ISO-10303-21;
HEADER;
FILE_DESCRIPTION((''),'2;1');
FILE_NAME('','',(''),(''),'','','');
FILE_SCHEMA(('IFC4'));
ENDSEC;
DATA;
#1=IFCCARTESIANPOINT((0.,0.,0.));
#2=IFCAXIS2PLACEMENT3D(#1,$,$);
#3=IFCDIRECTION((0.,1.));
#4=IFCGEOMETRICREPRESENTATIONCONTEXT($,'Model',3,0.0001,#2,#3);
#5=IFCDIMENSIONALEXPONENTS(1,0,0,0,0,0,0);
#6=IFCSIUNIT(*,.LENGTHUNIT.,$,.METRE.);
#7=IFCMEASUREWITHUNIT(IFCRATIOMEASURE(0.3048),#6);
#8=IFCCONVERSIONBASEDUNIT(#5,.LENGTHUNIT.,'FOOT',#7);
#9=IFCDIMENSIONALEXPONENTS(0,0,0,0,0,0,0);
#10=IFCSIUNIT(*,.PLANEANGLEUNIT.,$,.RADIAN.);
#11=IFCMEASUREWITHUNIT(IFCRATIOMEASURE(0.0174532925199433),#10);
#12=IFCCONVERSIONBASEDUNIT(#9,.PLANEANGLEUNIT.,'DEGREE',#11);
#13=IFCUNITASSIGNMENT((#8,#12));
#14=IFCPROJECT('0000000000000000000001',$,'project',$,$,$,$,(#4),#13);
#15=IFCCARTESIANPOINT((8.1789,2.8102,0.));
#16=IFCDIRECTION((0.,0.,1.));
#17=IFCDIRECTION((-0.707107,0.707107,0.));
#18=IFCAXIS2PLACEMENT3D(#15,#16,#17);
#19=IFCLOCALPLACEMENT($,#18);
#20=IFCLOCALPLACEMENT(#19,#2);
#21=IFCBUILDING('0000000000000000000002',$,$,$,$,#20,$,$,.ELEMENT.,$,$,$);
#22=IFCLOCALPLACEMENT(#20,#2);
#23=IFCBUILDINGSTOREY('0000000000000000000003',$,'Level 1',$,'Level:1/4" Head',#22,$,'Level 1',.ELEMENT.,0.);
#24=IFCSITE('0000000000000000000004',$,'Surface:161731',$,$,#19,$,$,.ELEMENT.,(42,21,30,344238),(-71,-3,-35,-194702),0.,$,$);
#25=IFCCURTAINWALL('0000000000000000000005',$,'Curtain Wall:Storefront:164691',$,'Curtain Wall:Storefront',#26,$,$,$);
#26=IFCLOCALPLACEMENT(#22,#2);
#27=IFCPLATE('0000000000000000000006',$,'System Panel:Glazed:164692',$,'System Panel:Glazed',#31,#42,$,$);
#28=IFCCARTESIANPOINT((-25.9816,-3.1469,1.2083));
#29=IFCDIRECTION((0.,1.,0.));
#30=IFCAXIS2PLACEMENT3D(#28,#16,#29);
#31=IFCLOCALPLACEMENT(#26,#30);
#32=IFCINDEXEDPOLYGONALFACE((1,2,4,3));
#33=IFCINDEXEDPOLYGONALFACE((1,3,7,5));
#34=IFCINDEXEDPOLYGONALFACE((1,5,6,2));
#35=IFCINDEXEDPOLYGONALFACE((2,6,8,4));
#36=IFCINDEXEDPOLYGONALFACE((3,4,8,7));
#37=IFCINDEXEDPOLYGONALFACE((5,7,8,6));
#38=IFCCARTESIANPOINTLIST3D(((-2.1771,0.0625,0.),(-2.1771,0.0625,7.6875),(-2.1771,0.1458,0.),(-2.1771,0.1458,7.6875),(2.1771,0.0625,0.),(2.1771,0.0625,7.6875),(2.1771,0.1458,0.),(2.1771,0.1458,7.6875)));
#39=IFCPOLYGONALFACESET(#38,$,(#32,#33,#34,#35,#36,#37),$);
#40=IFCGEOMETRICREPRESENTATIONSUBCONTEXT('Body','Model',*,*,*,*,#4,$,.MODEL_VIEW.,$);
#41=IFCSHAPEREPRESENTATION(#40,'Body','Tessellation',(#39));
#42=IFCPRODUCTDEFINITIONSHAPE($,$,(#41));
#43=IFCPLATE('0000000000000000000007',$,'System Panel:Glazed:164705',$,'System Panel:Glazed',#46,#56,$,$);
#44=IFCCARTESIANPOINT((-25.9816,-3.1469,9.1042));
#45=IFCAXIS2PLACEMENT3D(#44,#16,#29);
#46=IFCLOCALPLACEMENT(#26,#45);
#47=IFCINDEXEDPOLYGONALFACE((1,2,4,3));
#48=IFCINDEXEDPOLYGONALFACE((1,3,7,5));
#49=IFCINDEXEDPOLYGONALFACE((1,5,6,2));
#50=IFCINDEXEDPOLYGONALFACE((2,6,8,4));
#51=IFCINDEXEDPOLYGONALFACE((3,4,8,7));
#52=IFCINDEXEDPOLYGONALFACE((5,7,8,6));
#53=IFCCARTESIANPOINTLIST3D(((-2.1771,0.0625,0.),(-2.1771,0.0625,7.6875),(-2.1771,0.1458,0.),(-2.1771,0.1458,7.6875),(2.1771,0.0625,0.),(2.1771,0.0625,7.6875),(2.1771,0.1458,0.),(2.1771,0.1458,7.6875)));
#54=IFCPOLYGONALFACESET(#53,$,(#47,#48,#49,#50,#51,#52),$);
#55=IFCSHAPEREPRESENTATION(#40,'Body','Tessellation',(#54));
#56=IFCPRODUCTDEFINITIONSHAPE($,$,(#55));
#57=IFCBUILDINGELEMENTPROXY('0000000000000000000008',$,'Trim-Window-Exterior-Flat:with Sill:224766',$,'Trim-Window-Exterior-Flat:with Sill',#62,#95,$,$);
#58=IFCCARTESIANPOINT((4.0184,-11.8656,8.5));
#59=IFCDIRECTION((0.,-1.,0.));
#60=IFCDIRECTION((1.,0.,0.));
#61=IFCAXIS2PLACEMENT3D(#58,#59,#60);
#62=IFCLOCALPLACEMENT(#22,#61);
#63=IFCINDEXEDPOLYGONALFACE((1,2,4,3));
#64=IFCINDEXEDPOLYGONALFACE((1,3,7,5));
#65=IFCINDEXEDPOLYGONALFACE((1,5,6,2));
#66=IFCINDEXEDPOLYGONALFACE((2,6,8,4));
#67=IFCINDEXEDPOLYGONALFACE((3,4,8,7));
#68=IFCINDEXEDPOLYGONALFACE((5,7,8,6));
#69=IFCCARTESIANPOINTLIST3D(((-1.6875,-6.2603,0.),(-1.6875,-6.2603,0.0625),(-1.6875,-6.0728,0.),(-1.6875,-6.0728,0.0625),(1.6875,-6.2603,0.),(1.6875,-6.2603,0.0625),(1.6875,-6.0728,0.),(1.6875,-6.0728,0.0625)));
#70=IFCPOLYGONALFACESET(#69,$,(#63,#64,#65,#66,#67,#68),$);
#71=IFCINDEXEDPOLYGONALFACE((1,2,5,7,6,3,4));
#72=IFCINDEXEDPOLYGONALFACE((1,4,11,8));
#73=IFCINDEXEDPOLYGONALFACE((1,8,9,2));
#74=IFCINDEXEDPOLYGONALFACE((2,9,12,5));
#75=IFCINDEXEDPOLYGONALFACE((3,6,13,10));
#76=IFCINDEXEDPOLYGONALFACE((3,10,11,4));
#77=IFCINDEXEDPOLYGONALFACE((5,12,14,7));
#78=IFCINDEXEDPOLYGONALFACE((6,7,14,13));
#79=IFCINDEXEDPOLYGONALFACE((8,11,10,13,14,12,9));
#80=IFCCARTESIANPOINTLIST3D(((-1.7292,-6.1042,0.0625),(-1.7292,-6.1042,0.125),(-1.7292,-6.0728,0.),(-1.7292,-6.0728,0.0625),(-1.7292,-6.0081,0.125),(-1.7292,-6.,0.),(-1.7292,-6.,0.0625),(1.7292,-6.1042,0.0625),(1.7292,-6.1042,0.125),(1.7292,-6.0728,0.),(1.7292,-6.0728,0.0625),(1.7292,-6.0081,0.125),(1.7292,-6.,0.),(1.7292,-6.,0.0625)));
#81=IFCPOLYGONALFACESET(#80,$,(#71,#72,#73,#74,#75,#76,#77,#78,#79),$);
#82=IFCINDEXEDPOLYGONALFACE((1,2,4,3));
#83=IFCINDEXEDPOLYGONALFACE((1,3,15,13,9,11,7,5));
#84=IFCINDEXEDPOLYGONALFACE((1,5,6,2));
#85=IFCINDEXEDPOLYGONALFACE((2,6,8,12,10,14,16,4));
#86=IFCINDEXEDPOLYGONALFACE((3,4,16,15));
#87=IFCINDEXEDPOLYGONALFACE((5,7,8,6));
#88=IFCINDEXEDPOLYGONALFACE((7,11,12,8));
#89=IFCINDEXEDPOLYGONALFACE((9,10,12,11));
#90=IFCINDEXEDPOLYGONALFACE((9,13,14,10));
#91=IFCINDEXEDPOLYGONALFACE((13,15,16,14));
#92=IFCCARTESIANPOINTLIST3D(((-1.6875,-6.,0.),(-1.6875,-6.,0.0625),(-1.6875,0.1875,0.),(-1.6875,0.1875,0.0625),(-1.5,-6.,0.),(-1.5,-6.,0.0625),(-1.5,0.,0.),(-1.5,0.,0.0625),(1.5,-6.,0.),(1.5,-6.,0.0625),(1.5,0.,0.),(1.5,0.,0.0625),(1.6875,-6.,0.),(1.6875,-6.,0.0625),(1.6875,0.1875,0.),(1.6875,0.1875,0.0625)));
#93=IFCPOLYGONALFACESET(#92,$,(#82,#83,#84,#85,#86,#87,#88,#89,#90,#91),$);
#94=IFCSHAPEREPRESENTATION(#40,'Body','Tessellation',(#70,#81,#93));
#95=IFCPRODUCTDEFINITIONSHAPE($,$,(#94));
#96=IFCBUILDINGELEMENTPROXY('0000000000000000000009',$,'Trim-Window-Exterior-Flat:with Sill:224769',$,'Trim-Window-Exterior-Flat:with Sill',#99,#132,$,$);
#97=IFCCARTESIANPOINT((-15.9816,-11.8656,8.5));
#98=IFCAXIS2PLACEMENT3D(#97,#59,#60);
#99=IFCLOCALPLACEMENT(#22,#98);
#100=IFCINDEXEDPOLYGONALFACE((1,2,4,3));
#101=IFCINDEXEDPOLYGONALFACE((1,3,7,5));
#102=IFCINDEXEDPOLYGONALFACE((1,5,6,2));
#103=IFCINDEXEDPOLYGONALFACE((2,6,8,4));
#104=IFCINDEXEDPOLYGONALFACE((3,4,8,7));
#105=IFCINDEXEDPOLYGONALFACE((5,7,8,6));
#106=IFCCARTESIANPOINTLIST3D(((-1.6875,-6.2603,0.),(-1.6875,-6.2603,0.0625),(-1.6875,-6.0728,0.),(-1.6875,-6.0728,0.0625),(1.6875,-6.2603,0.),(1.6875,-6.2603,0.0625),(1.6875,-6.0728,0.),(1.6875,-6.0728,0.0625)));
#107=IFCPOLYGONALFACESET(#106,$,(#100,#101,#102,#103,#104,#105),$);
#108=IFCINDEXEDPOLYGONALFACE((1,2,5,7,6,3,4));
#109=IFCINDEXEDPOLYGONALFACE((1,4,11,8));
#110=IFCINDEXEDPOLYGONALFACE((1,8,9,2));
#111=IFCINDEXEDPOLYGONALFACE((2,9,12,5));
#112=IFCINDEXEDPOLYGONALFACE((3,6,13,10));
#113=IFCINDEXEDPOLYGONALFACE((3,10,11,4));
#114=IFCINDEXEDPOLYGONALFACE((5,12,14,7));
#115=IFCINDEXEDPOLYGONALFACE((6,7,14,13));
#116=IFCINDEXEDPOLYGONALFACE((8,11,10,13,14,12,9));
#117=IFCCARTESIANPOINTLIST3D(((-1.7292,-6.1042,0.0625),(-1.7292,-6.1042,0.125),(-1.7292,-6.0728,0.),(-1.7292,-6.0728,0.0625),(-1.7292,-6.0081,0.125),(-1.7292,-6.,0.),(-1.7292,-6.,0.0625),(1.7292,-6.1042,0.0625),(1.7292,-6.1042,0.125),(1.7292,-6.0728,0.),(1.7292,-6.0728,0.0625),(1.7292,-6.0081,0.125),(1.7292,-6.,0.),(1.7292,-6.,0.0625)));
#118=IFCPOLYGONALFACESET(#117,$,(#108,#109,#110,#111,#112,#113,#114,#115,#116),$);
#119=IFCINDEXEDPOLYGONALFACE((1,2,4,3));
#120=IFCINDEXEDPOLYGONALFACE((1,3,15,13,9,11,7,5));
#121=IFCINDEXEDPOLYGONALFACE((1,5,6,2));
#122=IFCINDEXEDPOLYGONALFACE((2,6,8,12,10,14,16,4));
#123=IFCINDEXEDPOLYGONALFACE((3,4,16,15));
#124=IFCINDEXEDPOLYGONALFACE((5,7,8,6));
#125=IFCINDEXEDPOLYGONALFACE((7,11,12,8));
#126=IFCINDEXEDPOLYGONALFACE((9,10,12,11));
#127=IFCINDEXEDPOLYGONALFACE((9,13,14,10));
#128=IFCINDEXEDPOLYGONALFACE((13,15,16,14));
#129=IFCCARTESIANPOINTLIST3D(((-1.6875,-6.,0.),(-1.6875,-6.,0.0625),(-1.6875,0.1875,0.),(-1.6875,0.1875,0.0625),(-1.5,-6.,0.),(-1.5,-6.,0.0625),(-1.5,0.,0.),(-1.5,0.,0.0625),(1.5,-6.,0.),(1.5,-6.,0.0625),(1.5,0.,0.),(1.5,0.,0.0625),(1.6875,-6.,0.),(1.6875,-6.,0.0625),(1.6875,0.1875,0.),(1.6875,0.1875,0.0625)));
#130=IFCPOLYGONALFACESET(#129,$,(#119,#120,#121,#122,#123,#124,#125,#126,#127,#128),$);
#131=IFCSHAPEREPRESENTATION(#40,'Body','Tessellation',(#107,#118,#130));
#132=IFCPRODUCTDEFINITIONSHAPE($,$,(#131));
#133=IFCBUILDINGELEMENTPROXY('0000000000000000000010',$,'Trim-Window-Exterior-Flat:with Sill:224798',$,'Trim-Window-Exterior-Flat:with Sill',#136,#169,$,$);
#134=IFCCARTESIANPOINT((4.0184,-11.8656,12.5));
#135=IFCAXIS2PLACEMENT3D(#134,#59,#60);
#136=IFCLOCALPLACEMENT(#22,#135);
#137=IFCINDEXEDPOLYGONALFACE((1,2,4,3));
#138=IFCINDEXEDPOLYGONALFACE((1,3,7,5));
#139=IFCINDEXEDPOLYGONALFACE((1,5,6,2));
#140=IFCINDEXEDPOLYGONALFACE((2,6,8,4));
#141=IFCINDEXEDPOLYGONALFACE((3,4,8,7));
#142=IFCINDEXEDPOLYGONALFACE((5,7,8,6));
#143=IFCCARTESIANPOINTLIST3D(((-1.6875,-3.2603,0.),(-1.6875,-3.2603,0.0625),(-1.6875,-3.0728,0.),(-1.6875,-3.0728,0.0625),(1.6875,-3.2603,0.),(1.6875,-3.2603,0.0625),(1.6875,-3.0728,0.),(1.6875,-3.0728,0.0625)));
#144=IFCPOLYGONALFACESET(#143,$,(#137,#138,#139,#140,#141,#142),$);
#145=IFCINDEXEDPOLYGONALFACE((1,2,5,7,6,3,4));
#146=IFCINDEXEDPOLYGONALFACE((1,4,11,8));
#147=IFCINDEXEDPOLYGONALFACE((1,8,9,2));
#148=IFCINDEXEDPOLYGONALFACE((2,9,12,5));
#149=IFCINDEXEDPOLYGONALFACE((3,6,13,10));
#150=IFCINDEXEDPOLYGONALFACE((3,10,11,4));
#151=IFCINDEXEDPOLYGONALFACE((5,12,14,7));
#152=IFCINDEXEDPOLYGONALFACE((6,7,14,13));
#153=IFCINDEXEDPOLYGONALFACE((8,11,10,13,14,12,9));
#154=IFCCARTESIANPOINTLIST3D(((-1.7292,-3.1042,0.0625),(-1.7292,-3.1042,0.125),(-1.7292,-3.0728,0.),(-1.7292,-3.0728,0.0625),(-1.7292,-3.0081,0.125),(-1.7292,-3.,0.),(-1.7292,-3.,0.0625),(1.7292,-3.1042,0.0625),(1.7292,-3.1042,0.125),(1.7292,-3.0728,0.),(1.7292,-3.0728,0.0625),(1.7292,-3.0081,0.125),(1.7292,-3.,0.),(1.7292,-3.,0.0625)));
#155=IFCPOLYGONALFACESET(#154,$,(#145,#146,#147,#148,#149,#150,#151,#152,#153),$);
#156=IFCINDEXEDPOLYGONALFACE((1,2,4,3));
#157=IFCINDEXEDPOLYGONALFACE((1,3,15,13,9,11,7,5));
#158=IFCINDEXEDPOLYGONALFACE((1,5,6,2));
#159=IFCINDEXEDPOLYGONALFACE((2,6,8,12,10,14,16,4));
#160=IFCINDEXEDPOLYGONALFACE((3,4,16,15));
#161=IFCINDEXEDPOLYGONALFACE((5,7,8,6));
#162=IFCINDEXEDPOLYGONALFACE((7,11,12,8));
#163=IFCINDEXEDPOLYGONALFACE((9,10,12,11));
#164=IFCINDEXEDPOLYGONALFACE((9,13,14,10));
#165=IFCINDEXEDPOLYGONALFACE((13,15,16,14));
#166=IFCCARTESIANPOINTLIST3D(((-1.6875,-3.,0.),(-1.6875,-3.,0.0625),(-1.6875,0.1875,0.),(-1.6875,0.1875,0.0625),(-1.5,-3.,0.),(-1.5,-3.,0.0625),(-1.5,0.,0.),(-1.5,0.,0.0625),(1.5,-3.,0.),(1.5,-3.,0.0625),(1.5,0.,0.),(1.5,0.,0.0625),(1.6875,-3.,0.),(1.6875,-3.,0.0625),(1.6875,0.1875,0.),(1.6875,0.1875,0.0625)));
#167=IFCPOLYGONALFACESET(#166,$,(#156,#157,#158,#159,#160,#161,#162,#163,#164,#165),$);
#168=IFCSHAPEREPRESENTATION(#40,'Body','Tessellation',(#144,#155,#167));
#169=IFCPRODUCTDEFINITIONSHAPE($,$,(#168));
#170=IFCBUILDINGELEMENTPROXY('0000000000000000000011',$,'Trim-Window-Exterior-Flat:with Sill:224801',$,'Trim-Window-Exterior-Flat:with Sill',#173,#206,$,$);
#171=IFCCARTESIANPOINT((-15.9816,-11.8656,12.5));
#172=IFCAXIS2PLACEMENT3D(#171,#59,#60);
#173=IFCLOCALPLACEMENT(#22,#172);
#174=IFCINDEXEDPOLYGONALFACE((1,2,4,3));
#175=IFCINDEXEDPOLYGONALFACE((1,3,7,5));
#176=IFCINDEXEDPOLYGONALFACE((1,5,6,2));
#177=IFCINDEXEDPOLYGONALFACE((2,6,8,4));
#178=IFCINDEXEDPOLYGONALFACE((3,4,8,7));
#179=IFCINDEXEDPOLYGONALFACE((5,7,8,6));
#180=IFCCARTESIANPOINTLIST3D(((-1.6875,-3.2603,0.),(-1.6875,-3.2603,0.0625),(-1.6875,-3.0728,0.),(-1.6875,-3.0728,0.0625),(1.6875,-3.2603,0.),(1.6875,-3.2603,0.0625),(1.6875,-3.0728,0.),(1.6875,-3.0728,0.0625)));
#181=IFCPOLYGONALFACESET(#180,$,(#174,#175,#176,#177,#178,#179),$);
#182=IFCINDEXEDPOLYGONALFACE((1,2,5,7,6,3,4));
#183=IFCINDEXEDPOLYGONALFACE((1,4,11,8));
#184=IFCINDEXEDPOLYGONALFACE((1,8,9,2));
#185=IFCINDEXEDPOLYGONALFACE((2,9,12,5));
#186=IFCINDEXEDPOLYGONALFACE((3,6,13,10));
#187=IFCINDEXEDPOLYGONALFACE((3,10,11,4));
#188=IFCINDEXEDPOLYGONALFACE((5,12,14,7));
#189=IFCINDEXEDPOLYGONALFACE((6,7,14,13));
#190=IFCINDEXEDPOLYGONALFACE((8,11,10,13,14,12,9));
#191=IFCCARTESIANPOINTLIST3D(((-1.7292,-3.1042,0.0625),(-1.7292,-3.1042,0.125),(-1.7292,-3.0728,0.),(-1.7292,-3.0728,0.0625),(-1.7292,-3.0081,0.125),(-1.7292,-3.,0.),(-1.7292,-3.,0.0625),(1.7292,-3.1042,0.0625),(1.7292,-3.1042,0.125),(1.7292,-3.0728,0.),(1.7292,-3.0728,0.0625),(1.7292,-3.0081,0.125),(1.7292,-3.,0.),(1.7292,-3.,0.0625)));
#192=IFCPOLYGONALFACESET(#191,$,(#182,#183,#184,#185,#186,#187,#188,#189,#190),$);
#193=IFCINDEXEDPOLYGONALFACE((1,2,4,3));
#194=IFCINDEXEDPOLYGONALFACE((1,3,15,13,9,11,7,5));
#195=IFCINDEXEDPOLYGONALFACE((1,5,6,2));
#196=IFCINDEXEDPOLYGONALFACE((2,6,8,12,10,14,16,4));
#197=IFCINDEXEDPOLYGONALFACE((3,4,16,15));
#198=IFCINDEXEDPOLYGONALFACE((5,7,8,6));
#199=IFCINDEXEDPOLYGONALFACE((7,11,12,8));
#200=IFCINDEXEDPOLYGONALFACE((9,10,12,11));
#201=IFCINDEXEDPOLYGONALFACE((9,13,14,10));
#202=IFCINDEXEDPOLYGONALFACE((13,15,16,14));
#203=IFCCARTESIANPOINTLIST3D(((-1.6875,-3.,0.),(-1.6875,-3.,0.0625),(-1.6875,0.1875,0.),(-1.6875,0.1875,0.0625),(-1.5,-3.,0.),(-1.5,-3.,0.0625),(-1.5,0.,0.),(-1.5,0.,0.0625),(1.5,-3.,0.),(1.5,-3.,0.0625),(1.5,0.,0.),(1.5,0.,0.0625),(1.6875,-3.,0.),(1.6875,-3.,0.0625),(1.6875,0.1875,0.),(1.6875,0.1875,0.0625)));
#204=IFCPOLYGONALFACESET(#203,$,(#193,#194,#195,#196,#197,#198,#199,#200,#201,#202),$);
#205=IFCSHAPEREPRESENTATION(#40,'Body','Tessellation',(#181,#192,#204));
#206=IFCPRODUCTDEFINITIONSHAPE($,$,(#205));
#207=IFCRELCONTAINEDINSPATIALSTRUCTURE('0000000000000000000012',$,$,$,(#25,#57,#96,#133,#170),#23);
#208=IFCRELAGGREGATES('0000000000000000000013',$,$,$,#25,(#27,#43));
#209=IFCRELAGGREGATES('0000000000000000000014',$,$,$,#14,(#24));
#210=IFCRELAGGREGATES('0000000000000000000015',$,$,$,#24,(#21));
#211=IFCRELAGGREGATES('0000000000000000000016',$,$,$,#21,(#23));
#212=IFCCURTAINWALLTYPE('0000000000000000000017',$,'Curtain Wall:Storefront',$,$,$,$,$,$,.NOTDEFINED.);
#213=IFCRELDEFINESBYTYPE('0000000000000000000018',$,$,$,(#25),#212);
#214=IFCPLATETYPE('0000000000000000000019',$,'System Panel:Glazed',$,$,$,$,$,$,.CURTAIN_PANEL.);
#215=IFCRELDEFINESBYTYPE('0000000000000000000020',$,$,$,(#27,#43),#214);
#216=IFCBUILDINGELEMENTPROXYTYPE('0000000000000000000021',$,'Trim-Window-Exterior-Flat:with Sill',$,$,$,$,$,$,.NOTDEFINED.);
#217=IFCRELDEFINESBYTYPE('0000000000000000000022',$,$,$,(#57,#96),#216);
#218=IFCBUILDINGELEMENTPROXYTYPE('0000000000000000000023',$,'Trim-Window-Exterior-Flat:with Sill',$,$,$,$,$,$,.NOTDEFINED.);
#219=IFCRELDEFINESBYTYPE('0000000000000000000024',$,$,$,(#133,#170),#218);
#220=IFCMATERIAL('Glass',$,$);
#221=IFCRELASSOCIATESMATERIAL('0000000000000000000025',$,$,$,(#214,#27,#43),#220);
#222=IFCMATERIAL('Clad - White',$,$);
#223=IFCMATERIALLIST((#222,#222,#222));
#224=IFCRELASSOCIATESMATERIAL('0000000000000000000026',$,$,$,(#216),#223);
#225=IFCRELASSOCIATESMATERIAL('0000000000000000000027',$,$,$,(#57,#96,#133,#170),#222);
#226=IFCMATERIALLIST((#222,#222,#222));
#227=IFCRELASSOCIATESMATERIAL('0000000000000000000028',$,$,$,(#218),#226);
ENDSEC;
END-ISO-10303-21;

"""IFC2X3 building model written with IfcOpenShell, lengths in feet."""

from ifc_helpers import new_model, entity, si_unit, converted_unit, direction, frame, frame_2d, origin, origin_2d_with_axis, place, context, subcontext, project, spatial, polyline, rectangle, outline, extrude, source, transform, mapped, material, material_list, type_object, type_shapes, element, aggregate, save


model = new_model("IFC2X3")

# Units and contexts
model_context = context("Model", 3, precision=0.0001, world=origin(), true_north=direction((0.0, 1.0)))
body_context = subcontext(model_context, "Body", "Model", "MODEL_VIEW")
ifc_project = project(units=[converted_unit("LENGTHUNIT", "FOOT", entity("IfcRatioMeasure", 0.3048), si_unit("LENGTHUNIT", "METRE"), dimensions=[1, 0, 0, 0, 0, 0, 0]), converted_unit("PLANEANGLEUNIT", "DEGREE", entity("IfcRatioMeasure", 0.0174532925199433), si_unit("PLANEANGLEUNIT", "RADIAN"), dimensions=[0, 0, 0, 0, 0, 0, 0])], contexts=[model_context])

# Site, building, storey
site_placement = place(None, frame((8.1789, 2.8102, 0.0), z_axis=(0.0, 0.0, 1.0), x_axis=(-0.707107, 0.707107, 0.0)))
site = spatial("IfcSite", under=ifc_project, at=site_placement, Name="Surface:161731", CompositionType="ELEMENT", RefLatitude=(42, 21, 30, 344238), RefLongitude=(-71, -3, -35, -194702), RefElevation=0.0)
building_placement = place(site_placement, origin())
building = spatial("IfcBuilding", under=site, at=building_placement, CompositionType="ELEMENT")
storey_placement = place(building_placement, origin())
storey = spatial("IfcBuildingStorey", under=building, at=storey_placement, Name="Level 1", ObjectType="Level:1/4\" Head", LongName="Level 1", CompositionType="ELEMENT", Elevation=0.0)

# Curtain wall, plates
curtain_wall_type = type_object("IfcCurtainWallType", Name="Curtain Wall:Storefront", PredefinedType="NOTDEFINED")
curtain_wall_placement = place(storey_placement, origin())
curtain_wall = element("IfcCurtainWall", 1, at=curtain_wall_placement, inside=storey, type_object=curtain_wall_type, Name="Curtain Wall:Storefront:164691", ObjectType="Curtain Wall:Storefront")
ifc_material_1 = material(Name="Glass")
plate_type = type_object("IfcPlateType", Name="System Panel:Glazed", PredefinedType="CURTAIN_PANEL", material=ifc_material_1)
shared_shape_1 = source(origin(), body_context, "Body", "SweptSolid", [
    extrude(rectangle(XDim=0.0833, YDim=4.3542, at=frame_2d((0.0, 0.0), x_axis=(1.0, 0.0))), frame((0.0, 0.1042, 0.0), z_axis=(0.0, 0.0, 1.0), x_axis=(0.0, 1.0, 0.0)), (0.0, 0.0, 1.0), 7.6875),
])
type_shapes(plate_type, [shared_shape_1])
plate_1_placement = place(curtain_wall_placement, frame((-25.9816, -3.1469, 1.2083), z_axis=(0.0, 0.0, 1.0), x_axis=(0.0, 1.0, 0.0)))
plate_1 = element("IfcPlate", 2, at=plate_1_placement, type_object=plate_type, material=ifc_material_1, Name="System Panel:Glazed:164692", ObjectType="System Panel:Glazed", context=body_context, shape_type="MappedRepresentation", body=[
    mapped(shared_shape_1, transform((0.0, 0.0, 0.0), scale=1.0)),
])
plate_2_placement = place(curtain_wall_placement, frame((-25.9816, -3.1469, 9.1042), z_axis=(0.0, 0.0, 1.0), x_axis=(0.0, 1.0, 0.0)))
plate_2 = element("IfcPlate", 3, at=plate_2_placement, type_object=plate_type, material=ifc_material_1, Name="System Panel:Glazed:164705", ObjectType="System Panel:Glazed", context=body_context, shape_type="MappedRepresentation", body=[
    mapped(shared_shape_1, transform((0.0, 0.0, 0.0), scale=1.0)),
])
aggregate(curtain_wall, [plate_1, plate_2])

# Building element proxies
ifc_material_2 = material(Name="Clad - White")
ifc_material_list_1 = material_list([ifc_material_2, ifc_material_2, ifc_material_2])
building_element_proxy_type_1 = type_object("IfcBuildingElementProxyType", Name="Trim-Window-Exterior-Flat:with Sill", PredefinedType="NOTDEFINED", material=ifc_material_list_1)
shared_shape_2 = source(origin(), body_context, "Body", "SweptSolid", [
    extrude(rectangle(XDim=3.375, YDim=0.1875, at=origin_2d_with_axis()), frame((0.0, -6.1665, 0.0), z_axis=(0.0, 0.0, 1.0), x_axis=(-1.0, 0.0, 0.0)), (0.0, 0.0, 1.0), 0.0625),
    extrude(outline(polyline([(-0.0625, -0.0525), (0.0, -0.0525), (0.0, -0.0211), (0.0625, -0.0211), (0.0625, 0.0517), (0.0, 0.0517), (-0.0625, 0.0436), (-0.0625, -0.0525)])), frame((-1.7292, -6.0517, 0.0625), z_axis=(1.0, 0.0, 0.0), x_axis=(0.0, 0.0, -1.0)), (0.0, 0.0, 1.0), 3.4583),
    extrude(outline(polyline([(-3.1406, -1.6875), (3.0469, -1.6875), (3.0469, -1.5), (-2.9531, -1.5), (-2.9531, 1.5), (3.0469, 1.5), (3.0469, 1.6875), (-3.1406, 1.6875), (-3.1406, -1.6875)])), frame((0.0, -2.9531, 0.0), z_axis=(0.0, 0.0, 1.0), x_axis=(0.0, -1.0, 0.0)), (0.0, 0.0, 1.0), 0.0625),
])
type_shapes(building_element_proxy_type_1, [shared_shape_2])
for number, where, z_axis, x_axis, name in (
    (4, (4.0184, -11.8656, 8.5), (0.0, -1.0, 0.0), (1.0, 0.0, 0.0), "Trim-Window-Exterior-Flat:with Sill:224766"),
    (5, (-15.9816, -11.8656, 8.5), (0.0, -1.0, 0.0), (1.0, 0.0, 0.0), "Trim-Window-Exterior-Flat:with Sill:224769"),
):
    element("IfcBuildingElementProxy", number, at=place(storey_placement, frame(where, z_axis=z_axis, x_axis=x_axis)), inside=storey, type_object=building_element_proxy_type_1, material=ifc_material_2, Name=name, ObjectType="Trim-Window-Exterior-Flat:with Sill", context=body_context, shape_type="MappedRepresentation", body=[
        mapped(shared_shape_2, transform((0.0, 0.0, 0.0), scale=1.0)),
    ])
ifc_material_list_2 = material_list([ifc_material_2, ifc_material_2, ifc_material_2])
building_element_proxy_type_2 = type_object("IfcBuildingElementProxyType", Name="Trim-Window-Exterior-Flat:with Sill", PredefinedType="NOTDEFINED", material=ifc_material_list_2)
shared_shape_3 = source(origin(), body_context, "Body", "SweptSolid", [
    extrude(rectangle(XDim=3.375, YDim=0.1875, at=frame_2d((0.0, 0.0), x_axis=(1.0, 0.0))), frame((0.0, -3.1665, 0.0), z_axis=(0.0, 0.0, 1.0), x_axis=(-1.0, 0.0, 0.0)), (0.0, 0.0, 1.0), 0.0625),
    extrude(outline(polyline([(-0.0625, -0.0525), (0.0, -0.0525), (0.0, -0.0211), (0.0625, -0.0211), (0.0625, 0.0517), (0.0, 0.0517), (-0.0625, 0.0436), (-0.0625, -0.0525)])), frame((-1.7292, -3.0517, 0.0625), z_axis=(1.0, 0.0, 0.0), x_axis=(0.0, 0.0, -1.0)), (0.0, 0.0, 1.0), 3.4583),
    extrude(outline(polyline([(-1.6406, -1.6875), (1.5469, -1.6875), (1.5469, -1.5), (-1.4531, -1.5), (-1.4531, 1.5), (1.5469, 1.5), (1.5469, 1.6875), (-1.6406, 1.6875), (-1.6406, -1.6875)])), frame((0.0, -1.4531, 0.0), z_axis=(0.0, 0.0, 1.0), x_axis=(0.0, -1.0, 0.0)), (0.0, 0.0, 1.0), 0.0625),
])
type_shapes(building_element_proxy_type_2, [shared_shape_3])
for number, where, z_axis, x_axis, name in (
    (6, (4.0184, -11.8656, 12.5), (0.0, -1.0, 0.0), (1.0, 0.0, 0.0), "Trim-Window-Exterior-Flat:with Sill:224798"),
    (7, (-15.9816, -11.8656, 12.5), (0.0, -1.0, 0.0), (1.0, 0.0, 0.0), "Trim-Window-Exterior-Flat:with Sill:224801"),
):
    element("IfcBuildingElementProxy", number, at=place(storey_placement, frame(where, z_axis=z_axis, x_axis=x_axis)), inside=storey, type_object=building_element_proxy_type_2, material=ifc_material_2, Name=name, ObjectType="Trim-Window-Exterior-Flat:with Sill", context=body_context, shape_type="MappedRepresentation", body=[
        mapped(shared_shape_3, transform((0.0, 0.0, 0.0), scale=1.0)),
    ])

save(model, "model.ifc")
